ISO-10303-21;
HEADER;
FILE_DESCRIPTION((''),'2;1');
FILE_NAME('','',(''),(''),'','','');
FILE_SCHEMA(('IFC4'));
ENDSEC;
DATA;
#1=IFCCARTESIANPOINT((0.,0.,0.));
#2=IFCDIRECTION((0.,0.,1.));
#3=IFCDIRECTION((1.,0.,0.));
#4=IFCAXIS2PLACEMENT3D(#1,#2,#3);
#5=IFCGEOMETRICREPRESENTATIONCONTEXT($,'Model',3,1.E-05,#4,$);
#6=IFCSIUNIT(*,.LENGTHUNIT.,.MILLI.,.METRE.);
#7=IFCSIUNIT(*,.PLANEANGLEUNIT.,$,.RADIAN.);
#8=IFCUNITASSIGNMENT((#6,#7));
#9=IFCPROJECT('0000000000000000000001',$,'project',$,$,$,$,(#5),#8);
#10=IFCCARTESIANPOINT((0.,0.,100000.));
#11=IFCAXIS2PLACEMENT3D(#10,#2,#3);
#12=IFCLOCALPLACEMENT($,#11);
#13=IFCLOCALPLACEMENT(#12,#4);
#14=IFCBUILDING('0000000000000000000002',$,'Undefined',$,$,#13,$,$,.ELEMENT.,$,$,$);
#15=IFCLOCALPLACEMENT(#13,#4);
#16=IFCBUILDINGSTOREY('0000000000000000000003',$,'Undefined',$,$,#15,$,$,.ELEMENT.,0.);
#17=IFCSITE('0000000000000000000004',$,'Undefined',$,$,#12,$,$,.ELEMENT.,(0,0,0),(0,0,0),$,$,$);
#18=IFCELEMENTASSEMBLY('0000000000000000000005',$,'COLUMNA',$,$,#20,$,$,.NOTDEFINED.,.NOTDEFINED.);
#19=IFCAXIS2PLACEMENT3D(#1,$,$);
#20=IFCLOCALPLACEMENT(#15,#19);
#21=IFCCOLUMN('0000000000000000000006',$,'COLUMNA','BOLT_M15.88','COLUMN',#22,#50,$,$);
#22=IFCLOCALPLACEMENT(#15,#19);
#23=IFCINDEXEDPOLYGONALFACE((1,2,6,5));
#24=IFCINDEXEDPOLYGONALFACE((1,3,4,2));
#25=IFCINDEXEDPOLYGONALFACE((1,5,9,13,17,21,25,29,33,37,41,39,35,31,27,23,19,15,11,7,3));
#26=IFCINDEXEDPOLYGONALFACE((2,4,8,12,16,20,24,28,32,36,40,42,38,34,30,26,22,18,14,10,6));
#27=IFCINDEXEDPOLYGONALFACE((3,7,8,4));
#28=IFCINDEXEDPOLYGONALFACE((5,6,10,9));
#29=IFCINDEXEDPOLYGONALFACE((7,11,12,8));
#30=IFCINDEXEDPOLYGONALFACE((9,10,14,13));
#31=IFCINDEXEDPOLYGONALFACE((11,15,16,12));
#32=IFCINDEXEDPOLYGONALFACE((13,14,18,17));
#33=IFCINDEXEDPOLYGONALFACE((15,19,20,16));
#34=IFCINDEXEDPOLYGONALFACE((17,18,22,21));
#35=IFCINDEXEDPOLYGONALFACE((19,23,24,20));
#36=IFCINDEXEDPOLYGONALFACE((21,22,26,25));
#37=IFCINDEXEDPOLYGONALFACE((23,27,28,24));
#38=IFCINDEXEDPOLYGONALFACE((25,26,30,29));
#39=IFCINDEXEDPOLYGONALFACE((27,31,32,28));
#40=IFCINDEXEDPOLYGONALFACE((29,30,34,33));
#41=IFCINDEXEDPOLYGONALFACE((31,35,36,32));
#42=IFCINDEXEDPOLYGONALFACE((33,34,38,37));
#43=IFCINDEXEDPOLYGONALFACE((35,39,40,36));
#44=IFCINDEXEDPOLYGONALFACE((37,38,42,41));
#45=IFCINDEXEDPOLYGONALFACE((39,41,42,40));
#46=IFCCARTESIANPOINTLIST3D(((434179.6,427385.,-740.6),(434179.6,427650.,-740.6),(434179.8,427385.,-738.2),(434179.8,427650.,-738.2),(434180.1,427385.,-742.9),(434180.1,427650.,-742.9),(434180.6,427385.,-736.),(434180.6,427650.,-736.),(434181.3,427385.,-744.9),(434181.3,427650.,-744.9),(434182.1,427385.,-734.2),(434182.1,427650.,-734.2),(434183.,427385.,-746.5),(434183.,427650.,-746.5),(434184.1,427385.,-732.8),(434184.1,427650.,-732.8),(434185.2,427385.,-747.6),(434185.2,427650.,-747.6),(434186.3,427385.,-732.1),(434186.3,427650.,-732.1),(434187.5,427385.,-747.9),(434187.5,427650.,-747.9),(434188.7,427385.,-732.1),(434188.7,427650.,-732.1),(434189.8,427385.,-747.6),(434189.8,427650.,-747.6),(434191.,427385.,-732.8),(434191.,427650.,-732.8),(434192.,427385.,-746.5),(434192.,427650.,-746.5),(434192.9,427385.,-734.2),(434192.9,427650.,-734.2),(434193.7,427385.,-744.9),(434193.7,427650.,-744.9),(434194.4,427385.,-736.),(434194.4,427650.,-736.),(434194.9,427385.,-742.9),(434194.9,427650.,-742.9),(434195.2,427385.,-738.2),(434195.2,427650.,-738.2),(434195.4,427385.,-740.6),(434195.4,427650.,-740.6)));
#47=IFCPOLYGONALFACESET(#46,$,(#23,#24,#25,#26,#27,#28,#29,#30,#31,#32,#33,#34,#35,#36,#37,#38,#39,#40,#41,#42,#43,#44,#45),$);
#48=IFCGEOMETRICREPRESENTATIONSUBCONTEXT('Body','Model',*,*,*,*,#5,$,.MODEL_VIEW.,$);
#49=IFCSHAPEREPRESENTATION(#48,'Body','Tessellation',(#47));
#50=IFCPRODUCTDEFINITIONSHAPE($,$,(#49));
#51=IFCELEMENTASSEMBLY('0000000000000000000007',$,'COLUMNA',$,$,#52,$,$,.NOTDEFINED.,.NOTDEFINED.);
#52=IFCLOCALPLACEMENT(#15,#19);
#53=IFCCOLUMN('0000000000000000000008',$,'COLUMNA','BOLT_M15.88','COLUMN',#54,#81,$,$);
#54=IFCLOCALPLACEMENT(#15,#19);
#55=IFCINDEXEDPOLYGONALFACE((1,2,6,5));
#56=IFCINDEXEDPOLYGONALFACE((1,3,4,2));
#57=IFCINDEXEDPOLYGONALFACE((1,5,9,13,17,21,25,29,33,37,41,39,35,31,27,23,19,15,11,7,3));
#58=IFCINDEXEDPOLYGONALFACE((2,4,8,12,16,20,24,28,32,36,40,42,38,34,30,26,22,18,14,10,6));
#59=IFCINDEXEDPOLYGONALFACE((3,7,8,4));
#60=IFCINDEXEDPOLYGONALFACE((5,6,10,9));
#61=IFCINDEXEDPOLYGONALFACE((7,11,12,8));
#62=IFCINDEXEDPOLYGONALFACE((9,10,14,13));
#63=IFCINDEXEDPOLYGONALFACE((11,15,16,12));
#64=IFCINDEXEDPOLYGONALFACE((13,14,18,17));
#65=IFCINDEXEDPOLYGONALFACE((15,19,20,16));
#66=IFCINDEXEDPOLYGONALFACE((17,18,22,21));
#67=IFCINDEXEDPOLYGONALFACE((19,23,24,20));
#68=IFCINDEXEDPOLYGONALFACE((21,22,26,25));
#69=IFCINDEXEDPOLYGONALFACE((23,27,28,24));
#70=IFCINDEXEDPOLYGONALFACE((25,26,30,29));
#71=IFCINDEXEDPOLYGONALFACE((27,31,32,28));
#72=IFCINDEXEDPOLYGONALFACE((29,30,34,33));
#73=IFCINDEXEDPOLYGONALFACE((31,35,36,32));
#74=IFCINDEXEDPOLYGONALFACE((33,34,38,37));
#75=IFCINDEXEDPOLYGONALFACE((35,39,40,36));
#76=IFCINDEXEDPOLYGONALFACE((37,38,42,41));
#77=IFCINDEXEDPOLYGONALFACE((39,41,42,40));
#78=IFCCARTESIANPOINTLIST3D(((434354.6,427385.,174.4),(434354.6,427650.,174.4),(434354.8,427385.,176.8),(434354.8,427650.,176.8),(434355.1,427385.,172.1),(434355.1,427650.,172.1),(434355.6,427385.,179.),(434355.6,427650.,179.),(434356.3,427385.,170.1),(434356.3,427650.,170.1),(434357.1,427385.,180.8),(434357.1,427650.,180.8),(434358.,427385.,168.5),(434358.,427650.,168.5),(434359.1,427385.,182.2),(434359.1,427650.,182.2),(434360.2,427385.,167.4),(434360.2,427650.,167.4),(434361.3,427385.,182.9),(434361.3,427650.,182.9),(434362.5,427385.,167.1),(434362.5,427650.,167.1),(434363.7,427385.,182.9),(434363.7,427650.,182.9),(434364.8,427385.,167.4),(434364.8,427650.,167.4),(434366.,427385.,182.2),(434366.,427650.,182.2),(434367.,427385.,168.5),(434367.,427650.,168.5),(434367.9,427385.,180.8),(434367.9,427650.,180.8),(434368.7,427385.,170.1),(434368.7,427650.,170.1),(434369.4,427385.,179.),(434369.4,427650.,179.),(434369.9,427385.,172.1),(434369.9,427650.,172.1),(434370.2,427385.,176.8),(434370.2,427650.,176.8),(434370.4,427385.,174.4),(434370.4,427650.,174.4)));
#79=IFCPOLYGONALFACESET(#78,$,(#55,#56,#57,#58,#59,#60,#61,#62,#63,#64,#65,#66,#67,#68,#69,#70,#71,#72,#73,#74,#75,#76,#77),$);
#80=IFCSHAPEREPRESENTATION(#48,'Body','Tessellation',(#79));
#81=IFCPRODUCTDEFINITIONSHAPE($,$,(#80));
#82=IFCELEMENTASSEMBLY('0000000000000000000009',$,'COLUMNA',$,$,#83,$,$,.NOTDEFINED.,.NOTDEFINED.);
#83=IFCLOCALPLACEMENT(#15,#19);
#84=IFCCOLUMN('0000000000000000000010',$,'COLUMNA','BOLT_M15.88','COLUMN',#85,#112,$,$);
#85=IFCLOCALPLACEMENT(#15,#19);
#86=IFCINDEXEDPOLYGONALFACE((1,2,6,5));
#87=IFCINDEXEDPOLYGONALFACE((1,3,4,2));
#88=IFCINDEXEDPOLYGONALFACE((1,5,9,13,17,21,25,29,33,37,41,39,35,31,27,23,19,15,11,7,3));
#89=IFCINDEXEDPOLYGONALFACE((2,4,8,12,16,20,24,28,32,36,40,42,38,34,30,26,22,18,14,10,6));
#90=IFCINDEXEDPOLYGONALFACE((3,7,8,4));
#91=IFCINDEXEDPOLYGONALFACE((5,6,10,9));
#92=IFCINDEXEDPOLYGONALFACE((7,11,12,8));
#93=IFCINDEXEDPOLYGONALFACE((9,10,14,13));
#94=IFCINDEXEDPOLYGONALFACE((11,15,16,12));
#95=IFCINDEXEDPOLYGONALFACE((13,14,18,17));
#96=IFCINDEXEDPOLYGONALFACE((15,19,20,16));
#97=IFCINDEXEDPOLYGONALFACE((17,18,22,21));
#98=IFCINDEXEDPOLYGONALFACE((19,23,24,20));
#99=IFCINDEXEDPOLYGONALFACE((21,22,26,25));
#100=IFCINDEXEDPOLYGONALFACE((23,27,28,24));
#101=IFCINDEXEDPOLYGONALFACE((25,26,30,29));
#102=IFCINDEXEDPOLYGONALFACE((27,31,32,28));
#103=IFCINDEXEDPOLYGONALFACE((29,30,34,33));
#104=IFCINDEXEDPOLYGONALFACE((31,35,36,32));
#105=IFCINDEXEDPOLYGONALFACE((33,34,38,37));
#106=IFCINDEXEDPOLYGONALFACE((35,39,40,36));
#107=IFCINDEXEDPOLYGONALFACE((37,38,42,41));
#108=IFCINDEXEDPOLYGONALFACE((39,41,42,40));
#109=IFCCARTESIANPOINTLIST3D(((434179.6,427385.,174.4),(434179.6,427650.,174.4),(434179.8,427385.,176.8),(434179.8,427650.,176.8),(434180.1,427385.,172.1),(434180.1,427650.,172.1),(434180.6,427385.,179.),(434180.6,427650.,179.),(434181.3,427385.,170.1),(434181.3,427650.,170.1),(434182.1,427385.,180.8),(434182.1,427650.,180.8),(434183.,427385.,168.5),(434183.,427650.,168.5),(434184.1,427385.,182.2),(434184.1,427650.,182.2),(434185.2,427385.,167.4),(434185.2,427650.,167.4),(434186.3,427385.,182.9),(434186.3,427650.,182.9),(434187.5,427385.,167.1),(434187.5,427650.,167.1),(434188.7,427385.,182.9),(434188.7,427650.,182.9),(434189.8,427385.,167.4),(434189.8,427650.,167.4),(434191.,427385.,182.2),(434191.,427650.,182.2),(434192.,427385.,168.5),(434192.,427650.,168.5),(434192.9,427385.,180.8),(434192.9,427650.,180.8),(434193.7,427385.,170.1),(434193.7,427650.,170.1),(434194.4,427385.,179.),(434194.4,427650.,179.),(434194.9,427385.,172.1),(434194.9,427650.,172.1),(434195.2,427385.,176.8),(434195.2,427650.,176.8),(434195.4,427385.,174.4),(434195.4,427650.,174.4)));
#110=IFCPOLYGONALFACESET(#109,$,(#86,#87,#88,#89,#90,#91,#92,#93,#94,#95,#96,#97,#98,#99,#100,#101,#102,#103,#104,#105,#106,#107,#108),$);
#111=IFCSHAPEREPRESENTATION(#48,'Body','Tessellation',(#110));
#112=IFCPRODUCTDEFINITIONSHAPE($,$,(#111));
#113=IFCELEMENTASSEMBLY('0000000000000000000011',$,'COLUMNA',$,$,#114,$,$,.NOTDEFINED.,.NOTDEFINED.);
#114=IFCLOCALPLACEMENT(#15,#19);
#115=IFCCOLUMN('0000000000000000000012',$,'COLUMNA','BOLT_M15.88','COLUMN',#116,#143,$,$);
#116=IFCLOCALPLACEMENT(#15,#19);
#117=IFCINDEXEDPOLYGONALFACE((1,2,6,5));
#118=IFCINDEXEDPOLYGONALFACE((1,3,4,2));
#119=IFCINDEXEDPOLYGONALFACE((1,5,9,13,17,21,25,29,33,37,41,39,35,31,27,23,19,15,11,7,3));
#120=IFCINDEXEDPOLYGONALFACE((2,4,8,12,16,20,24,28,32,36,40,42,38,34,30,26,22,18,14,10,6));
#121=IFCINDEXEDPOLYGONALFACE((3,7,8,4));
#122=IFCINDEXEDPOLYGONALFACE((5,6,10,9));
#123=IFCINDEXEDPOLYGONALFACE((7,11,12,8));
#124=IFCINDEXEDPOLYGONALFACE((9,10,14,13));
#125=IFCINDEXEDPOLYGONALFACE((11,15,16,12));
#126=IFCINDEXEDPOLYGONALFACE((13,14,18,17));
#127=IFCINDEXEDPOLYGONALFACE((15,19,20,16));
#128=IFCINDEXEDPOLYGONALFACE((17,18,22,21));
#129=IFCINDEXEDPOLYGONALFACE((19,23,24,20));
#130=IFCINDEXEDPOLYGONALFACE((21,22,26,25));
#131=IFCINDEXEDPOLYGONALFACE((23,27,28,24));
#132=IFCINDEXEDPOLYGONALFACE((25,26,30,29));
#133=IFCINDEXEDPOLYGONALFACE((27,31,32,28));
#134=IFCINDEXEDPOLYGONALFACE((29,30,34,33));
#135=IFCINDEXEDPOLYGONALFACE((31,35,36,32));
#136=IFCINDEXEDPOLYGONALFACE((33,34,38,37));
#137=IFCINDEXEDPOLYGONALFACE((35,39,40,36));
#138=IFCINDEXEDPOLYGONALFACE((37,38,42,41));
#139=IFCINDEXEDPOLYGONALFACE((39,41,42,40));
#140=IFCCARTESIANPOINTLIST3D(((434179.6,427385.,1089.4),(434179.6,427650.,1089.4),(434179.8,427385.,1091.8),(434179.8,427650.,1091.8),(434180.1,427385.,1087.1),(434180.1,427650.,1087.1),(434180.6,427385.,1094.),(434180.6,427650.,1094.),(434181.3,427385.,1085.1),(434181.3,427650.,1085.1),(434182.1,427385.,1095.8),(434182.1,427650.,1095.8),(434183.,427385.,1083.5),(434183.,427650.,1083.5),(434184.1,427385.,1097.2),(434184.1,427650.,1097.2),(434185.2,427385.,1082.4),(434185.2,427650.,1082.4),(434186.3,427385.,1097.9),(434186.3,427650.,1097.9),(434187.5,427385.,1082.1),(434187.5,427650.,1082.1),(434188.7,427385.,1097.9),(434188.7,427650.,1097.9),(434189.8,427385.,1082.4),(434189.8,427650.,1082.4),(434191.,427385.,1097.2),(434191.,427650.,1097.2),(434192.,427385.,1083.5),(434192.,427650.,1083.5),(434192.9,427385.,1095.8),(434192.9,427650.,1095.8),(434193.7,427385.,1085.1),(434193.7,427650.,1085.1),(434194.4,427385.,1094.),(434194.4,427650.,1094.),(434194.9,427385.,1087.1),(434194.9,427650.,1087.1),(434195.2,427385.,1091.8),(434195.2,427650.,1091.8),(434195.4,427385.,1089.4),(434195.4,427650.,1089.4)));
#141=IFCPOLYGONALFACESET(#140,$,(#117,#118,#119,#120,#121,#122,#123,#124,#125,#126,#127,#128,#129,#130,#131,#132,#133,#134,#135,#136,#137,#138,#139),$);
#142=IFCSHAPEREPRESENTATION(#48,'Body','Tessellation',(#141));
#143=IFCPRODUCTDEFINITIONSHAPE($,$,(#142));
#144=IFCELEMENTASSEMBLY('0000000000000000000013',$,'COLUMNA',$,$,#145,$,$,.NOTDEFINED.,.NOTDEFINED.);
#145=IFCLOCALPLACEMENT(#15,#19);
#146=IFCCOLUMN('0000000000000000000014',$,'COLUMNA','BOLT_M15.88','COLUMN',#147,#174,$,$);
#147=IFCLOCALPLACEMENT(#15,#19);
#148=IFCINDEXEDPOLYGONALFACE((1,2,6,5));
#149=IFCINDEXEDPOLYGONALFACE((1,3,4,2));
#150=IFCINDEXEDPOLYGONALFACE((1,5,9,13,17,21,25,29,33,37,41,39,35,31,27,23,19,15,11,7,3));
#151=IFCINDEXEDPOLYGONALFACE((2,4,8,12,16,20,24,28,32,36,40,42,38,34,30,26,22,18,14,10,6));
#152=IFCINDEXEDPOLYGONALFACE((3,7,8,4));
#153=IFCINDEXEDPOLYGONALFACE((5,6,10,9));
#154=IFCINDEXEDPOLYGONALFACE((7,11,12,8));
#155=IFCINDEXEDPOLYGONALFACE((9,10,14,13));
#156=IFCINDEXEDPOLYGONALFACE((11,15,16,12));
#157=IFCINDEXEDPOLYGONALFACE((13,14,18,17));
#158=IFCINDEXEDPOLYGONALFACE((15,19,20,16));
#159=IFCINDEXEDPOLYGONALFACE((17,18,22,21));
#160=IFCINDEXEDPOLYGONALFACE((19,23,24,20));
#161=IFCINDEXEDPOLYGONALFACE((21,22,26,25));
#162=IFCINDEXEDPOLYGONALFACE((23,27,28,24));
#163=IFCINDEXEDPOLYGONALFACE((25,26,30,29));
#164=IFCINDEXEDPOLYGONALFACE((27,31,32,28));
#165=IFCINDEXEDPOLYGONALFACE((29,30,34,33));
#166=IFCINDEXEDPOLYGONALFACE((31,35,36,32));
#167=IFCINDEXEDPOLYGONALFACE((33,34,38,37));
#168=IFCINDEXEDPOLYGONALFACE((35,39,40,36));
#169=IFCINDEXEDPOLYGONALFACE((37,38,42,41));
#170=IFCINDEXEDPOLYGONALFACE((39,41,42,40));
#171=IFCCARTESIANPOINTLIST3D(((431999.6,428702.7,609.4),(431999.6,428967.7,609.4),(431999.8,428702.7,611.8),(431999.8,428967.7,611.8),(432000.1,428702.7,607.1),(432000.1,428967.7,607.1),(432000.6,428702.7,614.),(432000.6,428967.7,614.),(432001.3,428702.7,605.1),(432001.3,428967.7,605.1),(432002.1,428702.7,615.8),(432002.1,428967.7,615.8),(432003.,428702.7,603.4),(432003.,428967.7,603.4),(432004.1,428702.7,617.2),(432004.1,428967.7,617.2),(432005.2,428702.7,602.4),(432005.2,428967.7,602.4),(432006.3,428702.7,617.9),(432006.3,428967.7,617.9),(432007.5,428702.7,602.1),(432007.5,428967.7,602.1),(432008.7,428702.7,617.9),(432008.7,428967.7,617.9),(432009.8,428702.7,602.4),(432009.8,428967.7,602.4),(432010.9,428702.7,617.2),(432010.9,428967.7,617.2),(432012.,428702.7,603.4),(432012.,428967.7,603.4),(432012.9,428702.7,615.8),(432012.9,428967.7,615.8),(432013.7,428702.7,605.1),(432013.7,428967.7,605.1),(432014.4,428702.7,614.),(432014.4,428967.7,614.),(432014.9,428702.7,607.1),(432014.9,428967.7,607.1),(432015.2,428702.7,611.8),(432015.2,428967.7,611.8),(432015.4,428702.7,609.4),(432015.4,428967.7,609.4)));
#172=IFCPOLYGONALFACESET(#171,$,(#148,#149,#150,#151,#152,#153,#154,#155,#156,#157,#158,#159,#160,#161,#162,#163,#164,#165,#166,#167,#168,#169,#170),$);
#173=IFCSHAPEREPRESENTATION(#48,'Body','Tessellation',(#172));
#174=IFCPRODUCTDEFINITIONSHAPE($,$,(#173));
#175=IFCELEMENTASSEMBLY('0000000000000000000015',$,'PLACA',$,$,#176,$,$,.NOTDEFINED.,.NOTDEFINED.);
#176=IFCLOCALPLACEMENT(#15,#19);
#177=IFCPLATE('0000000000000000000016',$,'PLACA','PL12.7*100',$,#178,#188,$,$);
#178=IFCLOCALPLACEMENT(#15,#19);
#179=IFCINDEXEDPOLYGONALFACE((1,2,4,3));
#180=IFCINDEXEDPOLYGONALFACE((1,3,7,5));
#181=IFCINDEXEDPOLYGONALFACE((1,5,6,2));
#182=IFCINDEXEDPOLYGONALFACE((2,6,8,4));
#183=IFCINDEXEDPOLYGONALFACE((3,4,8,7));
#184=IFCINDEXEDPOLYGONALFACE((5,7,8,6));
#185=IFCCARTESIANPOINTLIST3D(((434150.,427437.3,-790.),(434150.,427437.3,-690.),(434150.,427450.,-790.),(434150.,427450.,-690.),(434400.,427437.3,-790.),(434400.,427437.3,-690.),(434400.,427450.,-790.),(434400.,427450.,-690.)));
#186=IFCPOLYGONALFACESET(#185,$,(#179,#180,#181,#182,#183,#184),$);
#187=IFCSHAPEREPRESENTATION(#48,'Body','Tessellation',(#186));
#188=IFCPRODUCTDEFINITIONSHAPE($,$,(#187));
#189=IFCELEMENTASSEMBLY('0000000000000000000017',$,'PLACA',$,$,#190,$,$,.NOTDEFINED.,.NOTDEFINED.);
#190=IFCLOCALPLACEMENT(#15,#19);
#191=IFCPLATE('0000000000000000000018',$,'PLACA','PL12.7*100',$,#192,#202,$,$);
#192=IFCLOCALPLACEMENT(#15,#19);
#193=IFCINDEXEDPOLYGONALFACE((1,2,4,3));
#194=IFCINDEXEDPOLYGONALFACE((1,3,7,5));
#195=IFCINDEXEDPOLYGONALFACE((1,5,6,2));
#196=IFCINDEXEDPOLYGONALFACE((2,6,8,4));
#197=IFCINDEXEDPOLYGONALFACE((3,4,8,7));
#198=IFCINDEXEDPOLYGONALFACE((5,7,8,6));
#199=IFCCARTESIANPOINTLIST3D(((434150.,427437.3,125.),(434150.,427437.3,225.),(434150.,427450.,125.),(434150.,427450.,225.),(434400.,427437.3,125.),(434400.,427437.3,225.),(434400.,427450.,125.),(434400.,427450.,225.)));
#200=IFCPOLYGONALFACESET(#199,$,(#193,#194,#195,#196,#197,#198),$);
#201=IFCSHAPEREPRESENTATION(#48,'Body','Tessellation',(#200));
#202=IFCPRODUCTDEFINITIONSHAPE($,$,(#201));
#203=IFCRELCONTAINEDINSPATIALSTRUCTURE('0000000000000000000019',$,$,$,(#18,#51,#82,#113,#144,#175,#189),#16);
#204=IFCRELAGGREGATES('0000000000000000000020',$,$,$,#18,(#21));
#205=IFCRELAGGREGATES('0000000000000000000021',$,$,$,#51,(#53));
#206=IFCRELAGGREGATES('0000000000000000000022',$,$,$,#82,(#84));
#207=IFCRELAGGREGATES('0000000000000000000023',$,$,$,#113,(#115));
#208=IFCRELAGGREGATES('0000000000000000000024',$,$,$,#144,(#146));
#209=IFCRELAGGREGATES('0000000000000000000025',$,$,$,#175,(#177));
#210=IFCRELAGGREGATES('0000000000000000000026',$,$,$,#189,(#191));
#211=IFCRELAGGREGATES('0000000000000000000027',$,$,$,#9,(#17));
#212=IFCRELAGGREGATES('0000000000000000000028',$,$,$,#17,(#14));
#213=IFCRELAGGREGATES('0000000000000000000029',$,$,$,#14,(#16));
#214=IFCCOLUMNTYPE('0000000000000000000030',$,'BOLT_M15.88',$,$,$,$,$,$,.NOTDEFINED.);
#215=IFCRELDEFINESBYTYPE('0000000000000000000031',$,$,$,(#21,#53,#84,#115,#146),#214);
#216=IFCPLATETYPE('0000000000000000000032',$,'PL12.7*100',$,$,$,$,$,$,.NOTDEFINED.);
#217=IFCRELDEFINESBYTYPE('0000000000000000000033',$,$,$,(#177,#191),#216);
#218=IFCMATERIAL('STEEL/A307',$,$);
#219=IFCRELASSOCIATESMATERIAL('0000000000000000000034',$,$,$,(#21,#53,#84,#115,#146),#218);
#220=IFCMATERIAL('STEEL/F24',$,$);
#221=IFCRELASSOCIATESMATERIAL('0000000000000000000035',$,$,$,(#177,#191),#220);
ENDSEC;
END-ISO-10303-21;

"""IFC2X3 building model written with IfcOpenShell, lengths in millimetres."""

from ifc_helpers import new_model, si_unit, frame, origin_with_axes, origin_2d_with_axis, place, context, subcontext, project, spatial, polyline, circle, outline, extrude, material, type_object, element, aggregate, save


model = new_model("IFC2X3")

# Units and contexts
model_context = context("Model", 3, precision=1e-05, world=origin_with_axes())
body_context = subcontext(model_context, "Body", "Model", "MODEL_VIEW")
ifc_project = project(units=[si_unit("LENGTHUNIT", "METRE", prefix="MILLI"), si_unit("PLANEANGLEUNIT", "RADIAN")], contexts=[model_context])

# Site, building, storey
site_placement = place(None, frame((0.0, 0.0, 100000.0), z_axis=(0.0, 0.0, 1.0), x_axis=(1.0, 0.0, 0.0)))
site = spatial("IfcSite", under=ifc_project, at=site_placement, Name="Undefined", CompositionType="ELEMENT", RefLatitude=(0, 0, 0), RefLongitude=(0, 0, 0))
building_placement = place(site_placement, origin_with_axes())
building = spatial("IfcBuilding", under=site, at=building_placement, Name="Undefined", CompositionType="ELEMENT")
storey_placement = place(building_placement, origin_with_axes())
storey = spatial("IfcBuildingStorey", under=building, at=storey_placement, Name="Undefined", CompositionType="ELEMENT", Elevation=0.0)

# Element assemblies, columns
ifc_material_1 = material(Name="STEEL/A307")
column_type_1 = type_object("IfcColumnType", Name="BOLT_M15.88", PredefinedType="NOTDEFINED")
assembly_1_placement = place(storey_placement, origin_with_axes())
assembly_1 = element("IfcElementAssembly", 1, at=assembly_1_placement, inside=storey, Name="COLUMNA", AssemblyPlace="NOTDEFINED", PredefinedType="NOTDEFINED")
column_1_placement = place(assembly_1_placement, frame((434187.5, 427650.0, -740.0), z_axis=(0.0, -1.0, -0.000003), x_axis=(-1.0, 0.0, 0.0)))
column_1 = element("IfcColumn", 2, at=column_1_placement, type_object=column_type_1, material=ifc_material_1, Name="COLUMNA", Description="BOLT_M15.88", ObjectType="COLUMN", context=body_context, shape_type="SweptSolid", body=[
    extrude(circle(Radius=7.9, at=origin_2d_with_axis()), frame((0.0, 0.0, 265.0), z_axis=(0.0, 0.0, -1.0), x_axis=(0.0, 1.0, 0.0)), (0.0, 0.0, 1.0), 265.0),
])
aggregate(assembly_1, [column_1])
assembly_2_placement = place(storey_placement, origin_with_axes())
assembly_2 = element("IfcElementAssembly", 3, at=assembly_2_placement, inside=storey, Name="COLUMNA", AssemblyPlace="NOTDEFINED", PredefinedType="NOTDEFINED")
column_2_placement = place(assembly_2_placement, frame((434362.5, 427650.0, 175.0), z_axis=(0.0, -1.0, -0.000003), x_axis=(-1.0, 0.0, 0.0)))
column_2 = element("IfcColumn", 4, at=column_2_placement, type_object=column_type_1, material=ifc_material_1, Name="COLUMNA", Description="BOLT_M15.88", ObjectType="COLUMN", context=body_context, shape_type="SweptSolid", body=[
    extrude(circle(Radius=7.9, at=origin_2d_with_axis()), frame((0.0, 0.0, 265.0), z_axis=(0.0, 0.0, -1.0), x_axis=(0.0, 1.0, 0.0)), (0.0, 0.0, 1.0), 265.0),
])
aggregate(assembly_2, [column_2])
assembly_3_placement = place(storey_placement, origin_with_axes())
assembly_3 = element("IfcElementAssembly", 5, at=assembly_3_placement, inside=storey, Name="COLUMNA", AssemblyPlace="NOTDEFINED", PredefinedType="NOTDEFINED")
column_3_placement = place(assembly_3_placement, frame((434187.5, 427650.0, 175.0), z_axis=(0.0, -1.0, -0.000003), x_axis=(-1.0, 0.0, 0.0)))
column_3 = element("IfcColumn", 6, at=column_3_placement, type_object=column_type_1, material=ifc_material_1, Name="COLUMNA", Description="BOLT_M15.88", ObjectType="COLUMN", context=body_context, shape_type="SweptSolid", body=[
    extrude(circle(Radius=7.9, at=origin_2d_with_axis()), frame((0.0, 0.0, 265.0), z_axis=(0.0, 0.0, -1.0), x_axis=(0.0, 1.0, 0.0)), (0.0, 0.0, 1.0), 265.0),
])
aggregate(assembly_3, [column_3])
assembly_4_placement = place(storey_placement, origin_with_axes())
assembly_4 = element("IfcElementAssembly", 7, at=assembly_4_placement, inside=storey, Name="COLUMNA", AssemblyPlace="NOTDEFINED", PredefinedType="NOTDEFINED")
column_4_placement = place(assembly_4_placement, frame((434187.5, 427650.0, 1090.0), z_axis=(0.0, -1.0, -0.000003), x_axis=(-1.0, 0.0, 0.0)))
column_4 = element("IfcColumn", 8, at=column_4_placement, type_object=column_type_1, material=ifc_material_1, Name="COLUMNA", Description="BOLT_M15.88", ObjectType="COLUMN", context=body_context, shape_type="SweptSolid", body=[
    extrude(circle(Radius=7.9, at=origin_2d_with_axis()), frame((0.0, 0.0, 265.0), z_axis=(0.0, 0.0, -1.0), x_axis=(0.0, 1.0, 0.0)), (0.0, 0.0, 1.0), 265.0),
])
aggregate(assembly_4, [column_4])
assembly_5_placement = place(storey_placement, origin_with_axes())
assembly_5 = element("IfcElementAssembly", 9, at=assembly_5_placement, inside=storey, Name="COLUMNA", AssemblyPlace="NOTDEFINED", PredefinedType="NOTDEFINED")
column_5_placement = place(assembly_5_placement, frame((432007.5, 428702.7, 610.0), z_axis=(0.0, 1.0, -0.000003), x_axis=(1.0, 0.0, 0.0)))
column_5 = element("IfcColumn", 10, at=column_5_placement, type_object=column_type_1, material=ifc_material_1, Name="COLUMNA", Description="BOLT_M15.88", ObjectType="COLUMN", context=body_context, shape_type="SweptSolid", body=[
    extrude(circle(Radius=7.9, at=origin_2d_with_axis()), frame((0.0, 0.0, 265.0), z_axis=(0.0, 0.0, -1.0), x_axis=(0.0, 1.0, 0.0)), (0.0, 0.0, 1.0), 265.0),
])
aggregate(assembly_5, [column_5])

# Element assemblies, plates
assembly_6_placement = place(storey_placement, origin_with_axes())
assembly_6 = element("IfcElementAssembly", 11, at=assembly_6_placement, inside=storey, Name="PLACA", AssemblyPlace="NOTDEFINED", PredefinedType="NOTDEFINED")
ifc_material_2 = material(Name="STEEL/F24")
plate_type = type_object("IfcPlateType", Name="PL12.7*100", PredefinedType="NOTDEFINED")
plate_1_placement = place(assembly_6_placement, frame((434150.0, 427443.6, -690.0), z_axis=(0.0, 1.0, 0.0), x_axis=(1.0, 0.0, 0.0)))
plate_1 = element("IfcPlate", 12, at=plate_1_placement, type_object=plate_type, material=ifc_material_2, Name="PLACA", Description="PL12.7*100", context=body_context, shape_type="SweptSolid", body=[
    extrude(outline(polyline([(0.0, 0.0), (250.0, 0.0), (250.0, 100.0), (0.0, 100.0), (0.0, 0.0)])), frame((0.0, 0.0, -6.3), z_axis=(0.0, 0.0, 1.0), x_axis=(1.0, 0.0, 0.0)), (0.0, 0.0, 1.0), 12.7),
])
aggregate(assembly_6, [plate_1])
assembly_7_placement = place(storey_placement, origin_with_axes())
assembly_7 = element("IfcElementAssembly", 13, at=assembly_7_placement, inside=storey, Name="PLACA", AssemblyPlace="NOTDEFINED", PredefinedType="NOTDEFINED")
plate_2_placement = place(assembly_7_placement, frame((434150.0, 427443.6, 225.0), z_axis=(0.0, 1.0, 0.0), x_axis=(1.0, 0.0, 0.0)))
plate_2 = element("IfcPlate", 14, at=plate_2_placement, type_object=plate_type, material=ifc_material_2, Name="PLACA", Description="PL12.7*100", context=body_context, shape_type="SweptSolid", body=[
    extrude(outline(polyline([(0.0, 0.0), (250.0, 0.0), (250.0, 100.0), (0.0, 100.0), (0.0, 0.0)])), frame((0.0, 0.0, -6.3), z_axis=(0.0, 0.0, 1.0), x_axis=(1.0, 0.0, 0.0)), (0.0, 0.0, 1.0), 12.7),
])
aggregate(assembly_7, [plate_2])

save(model, "model.ifc")
